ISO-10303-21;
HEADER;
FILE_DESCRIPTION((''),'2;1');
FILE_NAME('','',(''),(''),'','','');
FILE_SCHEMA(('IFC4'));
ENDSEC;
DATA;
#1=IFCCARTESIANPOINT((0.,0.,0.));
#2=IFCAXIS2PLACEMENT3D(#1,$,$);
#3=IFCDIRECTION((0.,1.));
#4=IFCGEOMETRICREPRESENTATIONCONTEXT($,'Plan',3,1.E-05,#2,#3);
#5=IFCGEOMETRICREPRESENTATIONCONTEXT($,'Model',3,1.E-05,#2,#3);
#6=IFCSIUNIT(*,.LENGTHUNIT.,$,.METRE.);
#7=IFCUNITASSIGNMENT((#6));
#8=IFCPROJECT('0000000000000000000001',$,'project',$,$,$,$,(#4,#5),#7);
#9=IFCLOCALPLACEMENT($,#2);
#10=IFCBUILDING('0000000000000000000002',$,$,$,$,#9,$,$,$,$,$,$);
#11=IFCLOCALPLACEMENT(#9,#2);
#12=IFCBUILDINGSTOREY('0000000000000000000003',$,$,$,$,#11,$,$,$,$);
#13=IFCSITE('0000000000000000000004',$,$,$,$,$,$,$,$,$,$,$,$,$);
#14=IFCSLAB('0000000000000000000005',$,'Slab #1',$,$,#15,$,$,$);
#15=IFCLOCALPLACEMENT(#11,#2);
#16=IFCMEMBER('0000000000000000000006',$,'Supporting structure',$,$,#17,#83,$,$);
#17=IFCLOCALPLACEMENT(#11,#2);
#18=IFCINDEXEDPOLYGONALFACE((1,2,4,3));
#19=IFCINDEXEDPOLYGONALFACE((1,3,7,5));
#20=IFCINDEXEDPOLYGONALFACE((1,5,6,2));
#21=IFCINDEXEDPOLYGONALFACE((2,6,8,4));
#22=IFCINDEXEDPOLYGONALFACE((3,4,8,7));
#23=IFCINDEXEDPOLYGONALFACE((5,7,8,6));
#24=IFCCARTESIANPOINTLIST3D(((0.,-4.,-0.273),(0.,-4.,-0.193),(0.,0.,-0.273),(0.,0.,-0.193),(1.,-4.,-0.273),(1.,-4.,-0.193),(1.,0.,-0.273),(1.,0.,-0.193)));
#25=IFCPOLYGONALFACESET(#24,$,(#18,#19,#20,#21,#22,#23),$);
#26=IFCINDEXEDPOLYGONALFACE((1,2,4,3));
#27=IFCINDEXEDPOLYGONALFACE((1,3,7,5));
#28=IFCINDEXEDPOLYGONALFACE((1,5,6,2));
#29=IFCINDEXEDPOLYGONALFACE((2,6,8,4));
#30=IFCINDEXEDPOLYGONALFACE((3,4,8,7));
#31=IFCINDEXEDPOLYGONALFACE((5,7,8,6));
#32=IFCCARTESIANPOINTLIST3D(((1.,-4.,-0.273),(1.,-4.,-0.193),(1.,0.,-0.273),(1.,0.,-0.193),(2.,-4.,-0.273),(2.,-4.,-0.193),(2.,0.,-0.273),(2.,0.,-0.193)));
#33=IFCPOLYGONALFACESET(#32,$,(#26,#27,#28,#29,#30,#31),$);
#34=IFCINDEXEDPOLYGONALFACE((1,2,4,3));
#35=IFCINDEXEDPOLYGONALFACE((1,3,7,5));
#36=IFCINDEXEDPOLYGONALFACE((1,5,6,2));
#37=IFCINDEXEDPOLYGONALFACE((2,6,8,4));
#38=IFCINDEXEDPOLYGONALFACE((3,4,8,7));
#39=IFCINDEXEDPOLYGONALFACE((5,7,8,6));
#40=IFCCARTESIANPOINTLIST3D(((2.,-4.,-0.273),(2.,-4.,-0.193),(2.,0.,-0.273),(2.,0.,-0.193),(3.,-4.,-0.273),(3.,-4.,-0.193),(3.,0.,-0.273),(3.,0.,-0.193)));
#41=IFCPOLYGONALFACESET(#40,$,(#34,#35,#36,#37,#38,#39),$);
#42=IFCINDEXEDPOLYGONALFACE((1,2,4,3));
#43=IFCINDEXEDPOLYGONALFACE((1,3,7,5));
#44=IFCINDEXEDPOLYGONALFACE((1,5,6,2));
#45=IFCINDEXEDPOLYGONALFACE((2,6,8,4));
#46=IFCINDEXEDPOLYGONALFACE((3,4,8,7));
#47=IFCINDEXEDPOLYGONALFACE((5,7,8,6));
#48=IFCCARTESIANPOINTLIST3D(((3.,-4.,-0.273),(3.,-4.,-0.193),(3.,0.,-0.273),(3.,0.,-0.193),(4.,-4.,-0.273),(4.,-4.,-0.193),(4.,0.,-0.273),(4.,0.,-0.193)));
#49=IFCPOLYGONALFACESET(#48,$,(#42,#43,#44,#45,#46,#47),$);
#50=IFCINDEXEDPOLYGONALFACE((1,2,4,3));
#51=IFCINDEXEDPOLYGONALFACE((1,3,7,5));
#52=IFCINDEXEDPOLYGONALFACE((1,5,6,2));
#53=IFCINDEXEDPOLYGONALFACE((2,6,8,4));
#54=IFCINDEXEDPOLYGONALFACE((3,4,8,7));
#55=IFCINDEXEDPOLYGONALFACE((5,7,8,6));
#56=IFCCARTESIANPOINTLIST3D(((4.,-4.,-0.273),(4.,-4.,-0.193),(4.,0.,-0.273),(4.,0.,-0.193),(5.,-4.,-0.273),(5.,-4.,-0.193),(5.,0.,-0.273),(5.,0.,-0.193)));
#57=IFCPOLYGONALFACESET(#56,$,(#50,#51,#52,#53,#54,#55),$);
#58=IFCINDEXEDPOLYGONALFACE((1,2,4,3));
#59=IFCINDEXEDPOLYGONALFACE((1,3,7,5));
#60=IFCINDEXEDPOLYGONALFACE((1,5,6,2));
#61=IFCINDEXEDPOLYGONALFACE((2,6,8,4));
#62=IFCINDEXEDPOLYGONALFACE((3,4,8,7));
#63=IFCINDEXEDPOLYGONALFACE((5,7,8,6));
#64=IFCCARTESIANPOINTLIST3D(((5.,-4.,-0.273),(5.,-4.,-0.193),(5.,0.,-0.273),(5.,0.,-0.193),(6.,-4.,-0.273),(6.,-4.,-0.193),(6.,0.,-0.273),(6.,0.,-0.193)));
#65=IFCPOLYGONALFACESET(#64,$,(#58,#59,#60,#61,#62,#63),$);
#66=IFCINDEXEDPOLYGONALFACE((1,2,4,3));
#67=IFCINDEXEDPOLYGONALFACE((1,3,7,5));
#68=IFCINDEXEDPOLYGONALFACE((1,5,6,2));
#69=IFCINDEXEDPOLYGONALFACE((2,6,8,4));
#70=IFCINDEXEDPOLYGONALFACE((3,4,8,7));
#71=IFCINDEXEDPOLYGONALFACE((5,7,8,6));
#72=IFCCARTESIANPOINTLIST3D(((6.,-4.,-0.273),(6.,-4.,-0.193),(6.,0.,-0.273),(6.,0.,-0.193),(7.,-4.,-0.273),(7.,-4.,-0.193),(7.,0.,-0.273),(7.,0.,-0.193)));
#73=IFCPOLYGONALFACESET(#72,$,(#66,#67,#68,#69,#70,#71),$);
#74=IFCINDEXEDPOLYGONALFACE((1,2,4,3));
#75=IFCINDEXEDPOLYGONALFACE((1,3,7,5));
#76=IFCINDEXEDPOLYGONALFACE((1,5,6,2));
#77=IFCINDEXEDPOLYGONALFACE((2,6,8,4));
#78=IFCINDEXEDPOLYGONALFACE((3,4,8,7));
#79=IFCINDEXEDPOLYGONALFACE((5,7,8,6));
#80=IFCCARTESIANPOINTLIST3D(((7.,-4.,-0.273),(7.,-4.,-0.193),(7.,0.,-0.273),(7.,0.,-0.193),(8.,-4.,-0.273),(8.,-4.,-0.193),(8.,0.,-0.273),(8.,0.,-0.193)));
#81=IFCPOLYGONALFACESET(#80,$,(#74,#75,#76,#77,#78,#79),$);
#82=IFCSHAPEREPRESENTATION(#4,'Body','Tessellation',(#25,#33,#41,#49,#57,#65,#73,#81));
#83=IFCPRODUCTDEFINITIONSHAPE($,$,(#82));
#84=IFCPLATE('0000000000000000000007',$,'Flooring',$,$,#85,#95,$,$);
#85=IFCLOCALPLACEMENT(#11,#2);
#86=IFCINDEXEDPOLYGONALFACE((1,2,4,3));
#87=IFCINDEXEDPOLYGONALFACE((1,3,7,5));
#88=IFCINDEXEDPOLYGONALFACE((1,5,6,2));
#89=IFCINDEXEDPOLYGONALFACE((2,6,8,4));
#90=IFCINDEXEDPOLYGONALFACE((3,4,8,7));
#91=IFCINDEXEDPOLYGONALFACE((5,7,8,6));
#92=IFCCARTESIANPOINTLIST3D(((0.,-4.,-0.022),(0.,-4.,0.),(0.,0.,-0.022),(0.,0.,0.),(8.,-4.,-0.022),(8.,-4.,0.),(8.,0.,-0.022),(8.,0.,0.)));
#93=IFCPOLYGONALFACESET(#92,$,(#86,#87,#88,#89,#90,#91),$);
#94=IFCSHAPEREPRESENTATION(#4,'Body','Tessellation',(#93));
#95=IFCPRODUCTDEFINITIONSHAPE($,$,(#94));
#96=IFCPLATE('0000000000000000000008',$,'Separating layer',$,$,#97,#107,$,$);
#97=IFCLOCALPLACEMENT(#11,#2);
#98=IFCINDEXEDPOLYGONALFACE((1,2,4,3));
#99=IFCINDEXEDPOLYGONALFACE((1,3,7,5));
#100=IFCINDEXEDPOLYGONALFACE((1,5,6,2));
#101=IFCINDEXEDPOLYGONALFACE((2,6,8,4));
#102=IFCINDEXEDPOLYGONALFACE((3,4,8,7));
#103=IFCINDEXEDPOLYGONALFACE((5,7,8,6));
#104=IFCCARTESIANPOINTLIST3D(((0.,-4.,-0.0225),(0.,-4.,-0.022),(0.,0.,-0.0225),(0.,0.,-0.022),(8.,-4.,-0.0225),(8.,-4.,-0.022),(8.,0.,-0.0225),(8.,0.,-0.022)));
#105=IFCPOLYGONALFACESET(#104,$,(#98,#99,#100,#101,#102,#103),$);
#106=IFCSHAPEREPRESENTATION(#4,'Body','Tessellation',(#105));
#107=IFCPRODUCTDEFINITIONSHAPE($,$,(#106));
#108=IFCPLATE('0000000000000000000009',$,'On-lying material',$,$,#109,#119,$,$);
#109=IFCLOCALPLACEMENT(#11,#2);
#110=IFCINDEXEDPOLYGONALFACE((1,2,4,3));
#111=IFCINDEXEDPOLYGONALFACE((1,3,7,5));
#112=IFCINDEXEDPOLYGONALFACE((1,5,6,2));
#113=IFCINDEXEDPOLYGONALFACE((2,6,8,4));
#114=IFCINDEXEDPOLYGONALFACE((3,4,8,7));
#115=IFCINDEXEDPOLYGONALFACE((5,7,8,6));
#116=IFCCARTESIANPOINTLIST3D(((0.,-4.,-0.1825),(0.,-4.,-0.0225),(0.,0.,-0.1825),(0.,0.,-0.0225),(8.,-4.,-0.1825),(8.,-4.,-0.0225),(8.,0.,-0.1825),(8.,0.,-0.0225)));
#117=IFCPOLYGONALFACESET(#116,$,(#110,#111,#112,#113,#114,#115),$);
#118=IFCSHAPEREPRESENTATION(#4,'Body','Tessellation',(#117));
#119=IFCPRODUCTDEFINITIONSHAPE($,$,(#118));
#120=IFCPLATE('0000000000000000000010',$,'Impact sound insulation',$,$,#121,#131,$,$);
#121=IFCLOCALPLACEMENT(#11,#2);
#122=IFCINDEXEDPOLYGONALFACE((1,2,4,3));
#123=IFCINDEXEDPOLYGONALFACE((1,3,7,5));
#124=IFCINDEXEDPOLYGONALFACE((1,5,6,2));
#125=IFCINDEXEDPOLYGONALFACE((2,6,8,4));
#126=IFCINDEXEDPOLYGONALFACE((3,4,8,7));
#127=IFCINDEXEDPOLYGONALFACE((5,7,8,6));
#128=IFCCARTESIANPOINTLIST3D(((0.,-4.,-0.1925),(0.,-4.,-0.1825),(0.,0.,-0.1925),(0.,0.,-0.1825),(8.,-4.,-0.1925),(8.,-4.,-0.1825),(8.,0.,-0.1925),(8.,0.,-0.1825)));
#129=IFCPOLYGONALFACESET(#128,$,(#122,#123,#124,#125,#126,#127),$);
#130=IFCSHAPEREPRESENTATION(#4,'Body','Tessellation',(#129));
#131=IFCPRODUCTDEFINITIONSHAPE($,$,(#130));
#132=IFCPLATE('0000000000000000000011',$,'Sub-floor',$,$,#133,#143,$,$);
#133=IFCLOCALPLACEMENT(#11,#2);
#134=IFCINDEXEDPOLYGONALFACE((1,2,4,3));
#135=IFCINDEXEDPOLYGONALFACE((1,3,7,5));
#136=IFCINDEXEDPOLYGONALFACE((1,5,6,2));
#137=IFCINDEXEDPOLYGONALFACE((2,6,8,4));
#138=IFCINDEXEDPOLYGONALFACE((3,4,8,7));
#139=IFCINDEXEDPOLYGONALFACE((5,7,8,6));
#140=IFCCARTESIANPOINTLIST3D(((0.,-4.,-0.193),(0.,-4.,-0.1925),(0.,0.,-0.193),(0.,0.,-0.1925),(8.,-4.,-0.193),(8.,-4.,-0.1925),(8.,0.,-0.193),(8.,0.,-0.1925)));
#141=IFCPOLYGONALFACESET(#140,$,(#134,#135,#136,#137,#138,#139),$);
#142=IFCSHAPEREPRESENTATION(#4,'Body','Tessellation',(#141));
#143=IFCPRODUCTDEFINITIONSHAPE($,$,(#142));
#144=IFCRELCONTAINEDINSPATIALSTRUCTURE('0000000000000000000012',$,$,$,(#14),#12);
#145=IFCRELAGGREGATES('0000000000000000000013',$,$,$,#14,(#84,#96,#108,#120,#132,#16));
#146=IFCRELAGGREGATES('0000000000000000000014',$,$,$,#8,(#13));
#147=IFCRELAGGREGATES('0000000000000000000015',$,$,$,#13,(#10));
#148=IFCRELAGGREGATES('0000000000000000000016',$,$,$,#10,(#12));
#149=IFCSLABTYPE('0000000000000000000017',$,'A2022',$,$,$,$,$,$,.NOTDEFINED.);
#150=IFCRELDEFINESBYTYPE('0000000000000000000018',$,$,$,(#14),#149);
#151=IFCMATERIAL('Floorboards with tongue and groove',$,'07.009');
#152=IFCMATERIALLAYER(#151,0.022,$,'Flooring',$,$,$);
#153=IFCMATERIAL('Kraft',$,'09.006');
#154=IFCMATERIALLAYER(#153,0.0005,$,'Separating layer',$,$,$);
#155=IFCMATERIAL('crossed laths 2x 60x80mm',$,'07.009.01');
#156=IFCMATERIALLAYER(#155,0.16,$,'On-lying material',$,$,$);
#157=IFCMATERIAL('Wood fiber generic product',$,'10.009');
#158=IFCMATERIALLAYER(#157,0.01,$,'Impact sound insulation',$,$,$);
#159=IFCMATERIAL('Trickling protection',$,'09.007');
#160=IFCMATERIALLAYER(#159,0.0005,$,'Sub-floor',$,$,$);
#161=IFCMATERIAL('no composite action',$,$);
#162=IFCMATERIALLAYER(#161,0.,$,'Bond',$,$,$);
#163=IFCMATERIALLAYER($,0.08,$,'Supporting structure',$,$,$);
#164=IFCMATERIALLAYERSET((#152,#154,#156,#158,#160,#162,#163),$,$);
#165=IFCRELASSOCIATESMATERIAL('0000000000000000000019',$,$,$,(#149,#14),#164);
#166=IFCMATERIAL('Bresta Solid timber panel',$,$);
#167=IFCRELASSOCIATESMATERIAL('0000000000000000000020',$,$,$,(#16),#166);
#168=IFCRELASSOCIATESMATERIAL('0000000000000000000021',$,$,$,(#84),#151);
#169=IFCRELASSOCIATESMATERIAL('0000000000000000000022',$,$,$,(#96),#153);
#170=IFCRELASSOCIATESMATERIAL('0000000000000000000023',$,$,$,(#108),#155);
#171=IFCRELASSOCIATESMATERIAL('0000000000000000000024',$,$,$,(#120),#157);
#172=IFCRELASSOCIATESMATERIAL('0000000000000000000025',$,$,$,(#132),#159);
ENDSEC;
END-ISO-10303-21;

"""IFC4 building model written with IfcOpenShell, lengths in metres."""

from ifc_helpers import new_model, si_unit, direction, frame, frame_2d, origin, origin_with_axes, place, context, project, spatial, rectangle, extrude, material, layer, layer_set, type_object, element, aggregate, save


model = new_model("IFC4")

# Units and contexts
plan_context = context("Plan", 3, precision=1e-05, world=origin(), true_north=direction((0.0, 1.0)))
model_context = context("Model", 3, precision=1e-05, world=origin(), true_north=direction((0.0, 1.0)))
ifc_project = project(units=[si_unit("LENGTHUNIT", "METRE")], contexts=[plan_context, model_context])

# Site, building, storey
site = spatial("IfcSite", under=ifc_project)
building_placement = place(None, origin())
building = spatial("IfcBuilding", under=site, at=building_placement)
storey_placement = place(building_placement, origin())
storey = spatial("IfcBuildingStorey", under=building, at=storey_placement)

# Slab, member, plates
ifc_material_1 = material(Name="Floorboards with tongue and groove", Category="07.009")
ifc_layer_1 = layer(ifc_material_1, 0.022, Name="Flooring")
ifc_material_2 = material(Name="Kraft", Category="09.006")
ifc_layer_2 = layer(ifc_material_2, 0.0005, Name="Separating layer")
ifc_material_3 = material(Name="crossed laths 2x 60x80mm", Category="07.009.01")
ifc_layer_3 = layer(ifc_material_3, 0.16, Name="On-lying material")
ifc_material_4 = material(Name="Wood fiber generic product", Category="10.009")
ifc_layer_4 = layer(ifc_material_4, 0.01, Name="Impact sound insulation")
ifc_material_5 = material(Name="Trickling protection", Category="09.007")
ifc_layer_5 = layer(ifc_material_5, 0.0005, Name="Sub-floor")
ifc_material_6 = material(Name="no composite action")
ifc_layer_6 = layer(ifc_material_6, 0.0, Name="Bond")
ifc_layer_7 = layer(None, 0.08, Name="Supporting structure")
ifc_layer_set = layer_set([ifc_layer_1, ifc_layer_2, ifc_layer_3, ifc_layer_4, ifc_layer_5, ifc_layer_6, ifc_layer_7])
slab_type = type_object("IfcSlabType", Name="A2022", PredefinedType="NOTDEFINED", material=ifc_layer_set)
slab_placement = place(None, frame((0.0, 0.0, 0.0), z_axis=(0.0, 0.0, -1.0), x_axis=(1.0, 0.0, 0.0)))
slab = element("IfcSlab", 1, at=slab_placement, inside=storey, type_object=slab_type, material=ifc_layer_set, Name="Slab #1")
ifc_material_7 = material(Name="Bresta Solid timber panel")
member_placement = place(slab_placement, origin())
member = element("IfcMember", 2, at=member_placement, material=ifc_material_7, Name="Supporting structure", context=plan_context, shape_type="SweptSolid", body=[
    extrude(rectangle(XDim=1.0, YDim=0.08, at=frame_2d((0.5, 0.04), x_axis=(1.0, 0.0))), frame((0.0, 4.0, 0.193), z_axis=(0.0, -1.0, 0.0), x_axis=(1.0, 0.0, 0.0)), (0.0, 0.0, 1.0), 4.0),
    extrude(rectangle(XDim=1.0, YDim=0.08, at=frame_2d((0.5, 0.04), x_axis=(1.0, 0.0))), frame((1.0, 4.0, 0.193), z_axis=(0.0, -1.0, 0.0), x_axis=(1.0, 0.0, 0.0)), (0.0, 0.0, 1.0), 4.0),
    extrude(rectangle(XDim=1.0, YDim=0.08, at=frame_2d((0.5, 0.04), x_axis=(1.0, 0.0))), frame((2.0, 4.0, 0.193), z_axis=(0.0, -1.0, 0.0), x_axis=(1.0, 0.0, 0.0)), (0.0, 0.0, 1.0), 4.0),
    extrude(rectangle(XDim=1.0, YDim=0.08, at=frame_2d((0.5, 0.04), x_axis=(1.0, 0.0))), frame((3.0, 4.0, 0.193), z_axis=(0.0, -1.0, 0.0), x_axis=(1.0, 0.0, 0.0)), (0.0, 0.0, 1.0), 4.0),
    extrude(rectangle(XDim=1.0, YDim=0.08, at=frame_2d((0.5, 0.04), x_axis=(1.0, 0.0))), frame((4.0, 4.0, 0.193), z_axis=(0.0, -1.0, 0.0), x_axis=(1.0, 0.0, 0.0)), (0.0, 0.0, 1.0), 4.0),
    extrude(rectangle(XDim=1.0, YDim=0.08, at=frame_2d((0.5, 0.04), x_axis=(1.0, 0.0))), frame((5.0, 4.0, 0.193), z_axis=(0.0, -1.0, 0.0), x_axis=(1.0, 0.0, 0.0)), (0.0, 0.0, 1.0), 4.0),
    extrude(rectangle(XDim=1.0, YDim=0.08, at=frame_2d((0.5, 0.04), x_axis=(1.0, 0.0))), frame((6.0, 4.0, 0.193), z_axis=(0.0, -1.0, 0.0), x_axis=(1.0, 0.0, 0.0)), (0.0, 0.0, 1.0), 4.0),
    extrude(rectangle(XDim=1.0, YDim=0.08, at=frame_2d((0.5, 0.04), x_axis=(1.0, 0.0))), frame((7.0, 4.0, 0.193), z_axis=(0.0, -1.0, 0.0), x_axis=(1.0, 0.0, 0.0)), (0.0, 0.0, 1.0), 4.0),
])
plate_1_placement = place(slab_placement, origin())
plate_1 = element("IfcPlate", 3, at=plate_1_placement, material=ifc_material_1, Name="Flooring", context=plan_context, shape_type="SweptSolid", body=[
    extrude(rectangle(XDim=8.0, YDim=4.0, at=frame_2d((4.0, 2.0), x_axis=(1.0, 0.0))), origin_with_axes(), (0.0, 0.0, 1.0), 0.022),
])
plate_2_placement = place(slab_placement, origin())
plate_2 = element("IfcPlate", 4, at=plate_2_placement, material=ifc_material_2, Name="Separating layer", context=plan_context, shape_type="SweptSolid", body=[
    extrude(rectangle(XDim=8.0, YDim=4.0, at=frame_2d((4.0, 2.0), x_axis=(1.0, 0.0))), frame((0.0, 0.0, 0.022), z_axis=(0.0, 0.0, 1.0), x_axis=(1.0, 0.0, 0.0)), (0.0, 0.0, 1.0), 0.0005),
])
plate_3_placement = place(slab_placement, origin())
plate_3 = element("IfcPlate", 5, at=plate_3_placement, material=ifc_material_3, Name="On-lying material", context=plan_context, shape_type="SweptSolid", body=[
    extrude(rectangle(XDim=8.0, YDim=4.0, at=frame_2d((4.0, 2.0), x_axis=(1.0, 0.0))), frame((0.0, 0.0, 0.0225), z_axis=(0.0, 0.0, 1.0), x_axis=(1.0, 0.0, 0.0)), (0.0, 0.0, 1.0), 0.16),
])
plate_4_placement = place(slab_placement, origin())
plate_4 = element("IfcPlate", 6, at=plate_4_placement, material=ifc_material_4, Name="Impact sound insulation", context=plan_context, shape_type="SweptSolid", body=[
    extrude(rectangle(XDim=8.0, YDim=4.0, at=frame_2d((4.0, 2.0), x_axis=(1.0, 0.0))), frame((0.0, 0.0, 0.1825), z_axis=(0.0, 0.0, 1.0), x_axis=(1.0, 0.0, 0.0)), (0.0, 0.0, 1.0), 0.01),
])
plate_5_placement = place(slab_placement, origin())
plate_5 = element("IfcPlate", 7, at=plate_5_placement, material=ifc_material_5, Name="Sub-floor", context=plan_context, shape_type="SweptSolid", body=[
    extrude(rectangle(XDim=8.0, YDim=4.0, at=frame_2d((4.0, 2.0), x_axis=(1.0, 0.0))), frame((0.0, 0.0, 0.1925), z_axis=(0.0, 0.0, 1.0), x_axis=(1.0, 0.0, 0.0)), (0.0, 0.0, 1.0), 0.0005),
])
aggregate(slab, [plate_1, plate_2, plate_3, plate_4, plate_5, member])

save(model, "model.ifc")
